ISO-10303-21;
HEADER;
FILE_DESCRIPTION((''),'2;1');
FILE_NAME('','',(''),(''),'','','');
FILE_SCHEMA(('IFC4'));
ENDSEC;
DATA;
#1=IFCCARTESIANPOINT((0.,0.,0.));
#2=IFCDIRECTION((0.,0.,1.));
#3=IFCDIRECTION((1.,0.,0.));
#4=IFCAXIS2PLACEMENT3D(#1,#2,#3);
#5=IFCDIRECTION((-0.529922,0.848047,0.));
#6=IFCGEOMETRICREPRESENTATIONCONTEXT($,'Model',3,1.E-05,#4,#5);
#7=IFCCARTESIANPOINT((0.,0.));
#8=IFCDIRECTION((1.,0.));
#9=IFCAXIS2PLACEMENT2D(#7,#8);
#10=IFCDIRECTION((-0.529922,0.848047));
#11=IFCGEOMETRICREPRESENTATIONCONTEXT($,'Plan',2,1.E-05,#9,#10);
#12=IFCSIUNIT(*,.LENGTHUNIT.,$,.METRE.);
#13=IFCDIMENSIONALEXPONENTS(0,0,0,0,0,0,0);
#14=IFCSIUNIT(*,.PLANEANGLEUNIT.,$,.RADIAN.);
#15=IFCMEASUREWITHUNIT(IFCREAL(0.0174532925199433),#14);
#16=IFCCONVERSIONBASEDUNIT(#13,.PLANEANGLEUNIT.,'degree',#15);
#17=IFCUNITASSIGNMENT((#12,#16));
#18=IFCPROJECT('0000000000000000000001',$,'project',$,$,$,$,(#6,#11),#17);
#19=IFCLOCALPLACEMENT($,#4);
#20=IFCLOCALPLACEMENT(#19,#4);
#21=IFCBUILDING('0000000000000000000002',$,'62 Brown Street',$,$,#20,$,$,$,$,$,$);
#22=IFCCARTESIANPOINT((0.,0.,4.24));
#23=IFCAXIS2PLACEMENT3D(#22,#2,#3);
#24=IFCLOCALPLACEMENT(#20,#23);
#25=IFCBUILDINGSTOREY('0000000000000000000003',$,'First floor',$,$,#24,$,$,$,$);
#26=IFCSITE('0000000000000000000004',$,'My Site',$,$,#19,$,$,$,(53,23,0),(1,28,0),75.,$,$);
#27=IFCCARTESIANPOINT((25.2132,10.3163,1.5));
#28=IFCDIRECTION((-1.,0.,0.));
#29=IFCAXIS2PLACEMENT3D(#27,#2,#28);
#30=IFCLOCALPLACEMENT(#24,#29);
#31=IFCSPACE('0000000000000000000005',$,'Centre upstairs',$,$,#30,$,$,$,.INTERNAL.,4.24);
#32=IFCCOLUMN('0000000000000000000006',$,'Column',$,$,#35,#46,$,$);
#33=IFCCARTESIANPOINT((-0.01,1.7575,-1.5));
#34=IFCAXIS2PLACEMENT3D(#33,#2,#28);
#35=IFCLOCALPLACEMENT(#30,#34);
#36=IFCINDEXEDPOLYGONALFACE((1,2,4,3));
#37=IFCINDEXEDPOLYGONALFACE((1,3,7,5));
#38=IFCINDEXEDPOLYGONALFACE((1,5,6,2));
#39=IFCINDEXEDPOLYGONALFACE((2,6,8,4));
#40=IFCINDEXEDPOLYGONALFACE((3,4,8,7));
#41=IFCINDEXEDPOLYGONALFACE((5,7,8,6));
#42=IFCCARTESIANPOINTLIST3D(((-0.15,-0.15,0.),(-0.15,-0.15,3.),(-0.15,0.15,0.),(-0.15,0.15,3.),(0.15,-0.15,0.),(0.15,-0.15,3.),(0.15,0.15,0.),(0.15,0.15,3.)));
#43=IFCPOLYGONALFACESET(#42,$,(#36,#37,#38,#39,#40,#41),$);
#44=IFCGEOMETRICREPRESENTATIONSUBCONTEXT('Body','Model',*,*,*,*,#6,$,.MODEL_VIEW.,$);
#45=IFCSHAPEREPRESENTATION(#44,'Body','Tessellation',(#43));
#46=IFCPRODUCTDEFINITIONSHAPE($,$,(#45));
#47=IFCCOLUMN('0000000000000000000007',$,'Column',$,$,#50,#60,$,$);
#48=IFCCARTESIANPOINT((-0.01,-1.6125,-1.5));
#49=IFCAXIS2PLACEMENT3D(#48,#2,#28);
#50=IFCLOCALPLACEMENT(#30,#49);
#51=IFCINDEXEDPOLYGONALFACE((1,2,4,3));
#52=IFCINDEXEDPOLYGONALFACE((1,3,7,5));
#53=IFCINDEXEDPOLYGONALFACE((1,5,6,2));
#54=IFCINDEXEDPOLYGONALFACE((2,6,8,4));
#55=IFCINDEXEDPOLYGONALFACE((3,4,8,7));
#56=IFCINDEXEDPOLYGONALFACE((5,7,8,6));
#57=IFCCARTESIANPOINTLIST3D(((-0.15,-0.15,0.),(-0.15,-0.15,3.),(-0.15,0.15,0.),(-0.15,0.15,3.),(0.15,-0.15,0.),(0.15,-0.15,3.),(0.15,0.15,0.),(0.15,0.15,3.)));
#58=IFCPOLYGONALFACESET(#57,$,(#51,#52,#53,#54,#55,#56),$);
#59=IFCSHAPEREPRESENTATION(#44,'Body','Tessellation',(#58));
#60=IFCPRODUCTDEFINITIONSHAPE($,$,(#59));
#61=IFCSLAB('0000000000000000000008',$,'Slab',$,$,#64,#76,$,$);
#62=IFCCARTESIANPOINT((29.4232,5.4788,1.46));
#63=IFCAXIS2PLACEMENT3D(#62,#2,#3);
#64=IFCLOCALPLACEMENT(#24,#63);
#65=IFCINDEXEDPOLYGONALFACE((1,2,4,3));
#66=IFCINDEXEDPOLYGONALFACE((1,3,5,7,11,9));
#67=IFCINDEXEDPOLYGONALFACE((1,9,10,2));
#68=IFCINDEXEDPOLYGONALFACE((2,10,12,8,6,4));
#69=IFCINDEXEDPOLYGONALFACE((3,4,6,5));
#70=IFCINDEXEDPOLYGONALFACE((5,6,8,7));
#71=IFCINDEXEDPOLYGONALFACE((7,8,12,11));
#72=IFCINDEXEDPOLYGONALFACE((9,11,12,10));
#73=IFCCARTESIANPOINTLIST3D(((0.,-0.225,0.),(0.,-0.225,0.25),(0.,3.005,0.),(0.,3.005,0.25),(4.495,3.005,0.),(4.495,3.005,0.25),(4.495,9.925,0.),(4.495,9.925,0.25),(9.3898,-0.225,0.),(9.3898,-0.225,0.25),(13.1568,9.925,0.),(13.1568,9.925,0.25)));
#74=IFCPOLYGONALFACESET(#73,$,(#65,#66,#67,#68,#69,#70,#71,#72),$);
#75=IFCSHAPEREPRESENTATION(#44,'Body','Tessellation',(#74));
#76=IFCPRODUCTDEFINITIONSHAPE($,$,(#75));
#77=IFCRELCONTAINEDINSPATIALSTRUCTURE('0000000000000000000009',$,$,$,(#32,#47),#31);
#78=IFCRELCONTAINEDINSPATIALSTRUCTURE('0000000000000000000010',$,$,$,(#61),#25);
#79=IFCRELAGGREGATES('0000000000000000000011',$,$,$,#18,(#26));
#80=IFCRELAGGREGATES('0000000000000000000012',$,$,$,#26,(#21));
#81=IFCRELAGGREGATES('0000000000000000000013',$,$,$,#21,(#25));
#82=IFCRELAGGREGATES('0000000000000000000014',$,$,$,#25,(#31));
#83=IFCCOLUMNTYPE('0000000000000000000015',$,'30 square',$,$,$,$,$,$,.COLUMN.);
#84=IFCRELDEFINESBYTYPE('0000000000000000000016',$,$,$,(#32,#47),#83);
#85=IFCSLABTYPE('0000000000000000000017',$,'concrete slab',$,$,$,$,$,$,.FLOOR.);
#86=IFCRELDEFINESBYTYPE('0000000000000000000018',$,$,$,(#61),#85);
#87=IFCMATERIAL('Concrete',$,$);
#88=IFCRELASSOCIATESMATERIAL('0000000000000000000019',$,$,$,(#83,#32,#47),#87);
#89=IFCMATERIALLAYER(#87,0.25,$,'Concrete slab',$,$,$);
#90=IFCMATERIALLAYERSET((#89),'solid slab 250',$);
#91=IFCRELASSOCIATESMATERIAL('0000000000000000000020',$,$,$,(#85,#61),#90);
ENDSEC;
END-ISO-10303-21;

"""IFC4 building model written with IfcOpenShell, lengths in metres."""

from ifc_helpers import new_model, entity, si_unit, converted_unit, direction, frame, origin_with_axes, origin_2d_with_axis, place, context, subcontext, project, spatial, line, indexed_curve, rectangle, outline, extrude, material, layer, layer_set, layer_usage, material_profile, profile_set, profile_usage, type_object, element, save


model = new_model("IFC4")

# Units and contexts
model_context = context("Model", 3, precision=1e-05, world=origin_with_axes(), true_north=direction((-0.529922, 0.848047, 0.0)))
plan_context = context("Plan", 2, precision=1e-05, world=origin_2d_with_axis(), true_north=direction((-0.529922, 0.848047)))
body_context_1 = subcontext(model_context, "Body", "Model", "MODEL_VIEW")
ifc_project = project(units=[si_unit("LENGTHUNIT", "METRE"), converted_unit("PLANEANGLEUNIT", "degree", entity("IfcReal", 0.0174532925199433), si_unit("PLANEANGLEUNIT", "RADIAN"), dimensions=[0, 0, 0, 0, 0, 0, 0])], contexts=[model_context, plan_context])

# Site, building, storey, space
site_placement = place(None, origin_with_axes())
site = spatial("IfcSite", under=ifc_project, at=site_placement, Name="My Site", RefLatitude=(53, 23, 0), RefLongitude=(1, 28, 0), RefElevation=75.0)
building_placement = place(site_placement, origin_with_axes())
building = spatial("IfcBuilding", under=site, at=building_placement, Name="62 Brown Street")
storey_placement = place(building_placement, frame((0.0, 0.0, 4.24), z_axis=(0.0, 0.0, 1.0), x_axis=(1.0, 0.0, 0.0)))
storey = spatial("IfcBuildingStorey", under=building, at=storey_placement, Name="First floor")
space_placement = place(storey_placement, frame((25.2132, 10.3163, 1.5), z_axis=(0.0, 0.0, 1.0), x_axis=(-1.0, 0.0, 0.0)))
space = spatial("IfcSpace", under=storey, at=space_placement, Name="Centre upstairs", PredefinedType="INTERNAL", ElevationWithFlooring=4.24)

# Columns
ifc_material_1 = material(Name="Concrete")
ifc_material_profile = material_profile(ifc_material_1, rectangle(XDim=0.3, YDim=0.3))
ifc_profile_set = profile_set([ifc_material_profile])
ifc_profile_usage_1 = profile_usage(ifc_profile_set, cardinal=5)
column_type = type_object("IfcColumnType", Name="30 square", PredefinedType="COLUMN", material=ifc_profile_set)
column_1_placement = place(space_placement, frame((-0.01, 1.7575, -1.5), z_axis=(0.0, 0.0, 1.0), x_axis=(-1.0, 0.0, 0.0)))
element("IfcColumn", 1, at=column_1_placement, inside=space, type_object=column_type, material=ifc_profile_usage_1, Name="Column", context=body_context_1, shape_type="SweptSolid", body=[
    extrude(rectangle(XDim=0.3, YDim=0.3), origin_with_axes(), (0.0, 0.0, 1.0), 3.0),
])
ifc_profile_usage_2 = profile_usage(ifc_profile_set, cardinal=5)
column_2_placement = place(space_placement, frame((-0.01, -1.6125, -1.5), z_axis=(0.0, 0.0, 1.0), x_axis=(-1.0, 0.0, 0.0)))
element("IfcColumn", 2, at=column_2_placement, inside=space, type_object=column_type, material=ifc_profile_usage_2, Name="Column", context=body_context_1, shape_type="SweptSolid", body=[
    extrude(rectangle(XDim=0.3, YDim=0.3), origin_with_axes(), (0.0, 0.0, 1.0), 3.0),
])

# Slab
ifc_layer_1 = layer(ifc_material_1, 0.25, Name="Concrete slab")
ifc_layer_set_1 = layer_set([ifc_layer_1], Name="solid slab 250")
slab_type = type_object("IfcSlabType", Name="concrete slab", PredefinedType="FLOOR", material=ifc_layer_set_1)
ifc_layer_usage_1 = layer_usage(ifc_layer_set_1, "AXIS3", "POSITIVE", 0.0)
slab_1_placement = place(storey_placement, frame((29.4232, 5.4788, 1.46), z_axis=(0.0, 0.0, 1.0), x_axis=(1.0, 0.0, 0.0)))
element("IfcSlab", 3, at=slab_1_placement, inside=storey, type_object=slab_type, material=ifc_layer_usage_1, Name="Slab", context=body_context_1, shape_type="SweptSolid", body=[
    extrude(outline(indexed_curve([(0.0, 3.005), (0.0, -0.225), (9.3898, -0.225), (13.1568, 9.925), (4.495, 9.925), (4.495, 3.005)], segments=[line(4, 3), line(3, 2), line(2, 1), line(1, 6), line(6, 5), line(5, 4)], self_intersect=False)), None, (0.0, 0.0, 1.0), 0.25),
])

save(model, "model.ifc")
